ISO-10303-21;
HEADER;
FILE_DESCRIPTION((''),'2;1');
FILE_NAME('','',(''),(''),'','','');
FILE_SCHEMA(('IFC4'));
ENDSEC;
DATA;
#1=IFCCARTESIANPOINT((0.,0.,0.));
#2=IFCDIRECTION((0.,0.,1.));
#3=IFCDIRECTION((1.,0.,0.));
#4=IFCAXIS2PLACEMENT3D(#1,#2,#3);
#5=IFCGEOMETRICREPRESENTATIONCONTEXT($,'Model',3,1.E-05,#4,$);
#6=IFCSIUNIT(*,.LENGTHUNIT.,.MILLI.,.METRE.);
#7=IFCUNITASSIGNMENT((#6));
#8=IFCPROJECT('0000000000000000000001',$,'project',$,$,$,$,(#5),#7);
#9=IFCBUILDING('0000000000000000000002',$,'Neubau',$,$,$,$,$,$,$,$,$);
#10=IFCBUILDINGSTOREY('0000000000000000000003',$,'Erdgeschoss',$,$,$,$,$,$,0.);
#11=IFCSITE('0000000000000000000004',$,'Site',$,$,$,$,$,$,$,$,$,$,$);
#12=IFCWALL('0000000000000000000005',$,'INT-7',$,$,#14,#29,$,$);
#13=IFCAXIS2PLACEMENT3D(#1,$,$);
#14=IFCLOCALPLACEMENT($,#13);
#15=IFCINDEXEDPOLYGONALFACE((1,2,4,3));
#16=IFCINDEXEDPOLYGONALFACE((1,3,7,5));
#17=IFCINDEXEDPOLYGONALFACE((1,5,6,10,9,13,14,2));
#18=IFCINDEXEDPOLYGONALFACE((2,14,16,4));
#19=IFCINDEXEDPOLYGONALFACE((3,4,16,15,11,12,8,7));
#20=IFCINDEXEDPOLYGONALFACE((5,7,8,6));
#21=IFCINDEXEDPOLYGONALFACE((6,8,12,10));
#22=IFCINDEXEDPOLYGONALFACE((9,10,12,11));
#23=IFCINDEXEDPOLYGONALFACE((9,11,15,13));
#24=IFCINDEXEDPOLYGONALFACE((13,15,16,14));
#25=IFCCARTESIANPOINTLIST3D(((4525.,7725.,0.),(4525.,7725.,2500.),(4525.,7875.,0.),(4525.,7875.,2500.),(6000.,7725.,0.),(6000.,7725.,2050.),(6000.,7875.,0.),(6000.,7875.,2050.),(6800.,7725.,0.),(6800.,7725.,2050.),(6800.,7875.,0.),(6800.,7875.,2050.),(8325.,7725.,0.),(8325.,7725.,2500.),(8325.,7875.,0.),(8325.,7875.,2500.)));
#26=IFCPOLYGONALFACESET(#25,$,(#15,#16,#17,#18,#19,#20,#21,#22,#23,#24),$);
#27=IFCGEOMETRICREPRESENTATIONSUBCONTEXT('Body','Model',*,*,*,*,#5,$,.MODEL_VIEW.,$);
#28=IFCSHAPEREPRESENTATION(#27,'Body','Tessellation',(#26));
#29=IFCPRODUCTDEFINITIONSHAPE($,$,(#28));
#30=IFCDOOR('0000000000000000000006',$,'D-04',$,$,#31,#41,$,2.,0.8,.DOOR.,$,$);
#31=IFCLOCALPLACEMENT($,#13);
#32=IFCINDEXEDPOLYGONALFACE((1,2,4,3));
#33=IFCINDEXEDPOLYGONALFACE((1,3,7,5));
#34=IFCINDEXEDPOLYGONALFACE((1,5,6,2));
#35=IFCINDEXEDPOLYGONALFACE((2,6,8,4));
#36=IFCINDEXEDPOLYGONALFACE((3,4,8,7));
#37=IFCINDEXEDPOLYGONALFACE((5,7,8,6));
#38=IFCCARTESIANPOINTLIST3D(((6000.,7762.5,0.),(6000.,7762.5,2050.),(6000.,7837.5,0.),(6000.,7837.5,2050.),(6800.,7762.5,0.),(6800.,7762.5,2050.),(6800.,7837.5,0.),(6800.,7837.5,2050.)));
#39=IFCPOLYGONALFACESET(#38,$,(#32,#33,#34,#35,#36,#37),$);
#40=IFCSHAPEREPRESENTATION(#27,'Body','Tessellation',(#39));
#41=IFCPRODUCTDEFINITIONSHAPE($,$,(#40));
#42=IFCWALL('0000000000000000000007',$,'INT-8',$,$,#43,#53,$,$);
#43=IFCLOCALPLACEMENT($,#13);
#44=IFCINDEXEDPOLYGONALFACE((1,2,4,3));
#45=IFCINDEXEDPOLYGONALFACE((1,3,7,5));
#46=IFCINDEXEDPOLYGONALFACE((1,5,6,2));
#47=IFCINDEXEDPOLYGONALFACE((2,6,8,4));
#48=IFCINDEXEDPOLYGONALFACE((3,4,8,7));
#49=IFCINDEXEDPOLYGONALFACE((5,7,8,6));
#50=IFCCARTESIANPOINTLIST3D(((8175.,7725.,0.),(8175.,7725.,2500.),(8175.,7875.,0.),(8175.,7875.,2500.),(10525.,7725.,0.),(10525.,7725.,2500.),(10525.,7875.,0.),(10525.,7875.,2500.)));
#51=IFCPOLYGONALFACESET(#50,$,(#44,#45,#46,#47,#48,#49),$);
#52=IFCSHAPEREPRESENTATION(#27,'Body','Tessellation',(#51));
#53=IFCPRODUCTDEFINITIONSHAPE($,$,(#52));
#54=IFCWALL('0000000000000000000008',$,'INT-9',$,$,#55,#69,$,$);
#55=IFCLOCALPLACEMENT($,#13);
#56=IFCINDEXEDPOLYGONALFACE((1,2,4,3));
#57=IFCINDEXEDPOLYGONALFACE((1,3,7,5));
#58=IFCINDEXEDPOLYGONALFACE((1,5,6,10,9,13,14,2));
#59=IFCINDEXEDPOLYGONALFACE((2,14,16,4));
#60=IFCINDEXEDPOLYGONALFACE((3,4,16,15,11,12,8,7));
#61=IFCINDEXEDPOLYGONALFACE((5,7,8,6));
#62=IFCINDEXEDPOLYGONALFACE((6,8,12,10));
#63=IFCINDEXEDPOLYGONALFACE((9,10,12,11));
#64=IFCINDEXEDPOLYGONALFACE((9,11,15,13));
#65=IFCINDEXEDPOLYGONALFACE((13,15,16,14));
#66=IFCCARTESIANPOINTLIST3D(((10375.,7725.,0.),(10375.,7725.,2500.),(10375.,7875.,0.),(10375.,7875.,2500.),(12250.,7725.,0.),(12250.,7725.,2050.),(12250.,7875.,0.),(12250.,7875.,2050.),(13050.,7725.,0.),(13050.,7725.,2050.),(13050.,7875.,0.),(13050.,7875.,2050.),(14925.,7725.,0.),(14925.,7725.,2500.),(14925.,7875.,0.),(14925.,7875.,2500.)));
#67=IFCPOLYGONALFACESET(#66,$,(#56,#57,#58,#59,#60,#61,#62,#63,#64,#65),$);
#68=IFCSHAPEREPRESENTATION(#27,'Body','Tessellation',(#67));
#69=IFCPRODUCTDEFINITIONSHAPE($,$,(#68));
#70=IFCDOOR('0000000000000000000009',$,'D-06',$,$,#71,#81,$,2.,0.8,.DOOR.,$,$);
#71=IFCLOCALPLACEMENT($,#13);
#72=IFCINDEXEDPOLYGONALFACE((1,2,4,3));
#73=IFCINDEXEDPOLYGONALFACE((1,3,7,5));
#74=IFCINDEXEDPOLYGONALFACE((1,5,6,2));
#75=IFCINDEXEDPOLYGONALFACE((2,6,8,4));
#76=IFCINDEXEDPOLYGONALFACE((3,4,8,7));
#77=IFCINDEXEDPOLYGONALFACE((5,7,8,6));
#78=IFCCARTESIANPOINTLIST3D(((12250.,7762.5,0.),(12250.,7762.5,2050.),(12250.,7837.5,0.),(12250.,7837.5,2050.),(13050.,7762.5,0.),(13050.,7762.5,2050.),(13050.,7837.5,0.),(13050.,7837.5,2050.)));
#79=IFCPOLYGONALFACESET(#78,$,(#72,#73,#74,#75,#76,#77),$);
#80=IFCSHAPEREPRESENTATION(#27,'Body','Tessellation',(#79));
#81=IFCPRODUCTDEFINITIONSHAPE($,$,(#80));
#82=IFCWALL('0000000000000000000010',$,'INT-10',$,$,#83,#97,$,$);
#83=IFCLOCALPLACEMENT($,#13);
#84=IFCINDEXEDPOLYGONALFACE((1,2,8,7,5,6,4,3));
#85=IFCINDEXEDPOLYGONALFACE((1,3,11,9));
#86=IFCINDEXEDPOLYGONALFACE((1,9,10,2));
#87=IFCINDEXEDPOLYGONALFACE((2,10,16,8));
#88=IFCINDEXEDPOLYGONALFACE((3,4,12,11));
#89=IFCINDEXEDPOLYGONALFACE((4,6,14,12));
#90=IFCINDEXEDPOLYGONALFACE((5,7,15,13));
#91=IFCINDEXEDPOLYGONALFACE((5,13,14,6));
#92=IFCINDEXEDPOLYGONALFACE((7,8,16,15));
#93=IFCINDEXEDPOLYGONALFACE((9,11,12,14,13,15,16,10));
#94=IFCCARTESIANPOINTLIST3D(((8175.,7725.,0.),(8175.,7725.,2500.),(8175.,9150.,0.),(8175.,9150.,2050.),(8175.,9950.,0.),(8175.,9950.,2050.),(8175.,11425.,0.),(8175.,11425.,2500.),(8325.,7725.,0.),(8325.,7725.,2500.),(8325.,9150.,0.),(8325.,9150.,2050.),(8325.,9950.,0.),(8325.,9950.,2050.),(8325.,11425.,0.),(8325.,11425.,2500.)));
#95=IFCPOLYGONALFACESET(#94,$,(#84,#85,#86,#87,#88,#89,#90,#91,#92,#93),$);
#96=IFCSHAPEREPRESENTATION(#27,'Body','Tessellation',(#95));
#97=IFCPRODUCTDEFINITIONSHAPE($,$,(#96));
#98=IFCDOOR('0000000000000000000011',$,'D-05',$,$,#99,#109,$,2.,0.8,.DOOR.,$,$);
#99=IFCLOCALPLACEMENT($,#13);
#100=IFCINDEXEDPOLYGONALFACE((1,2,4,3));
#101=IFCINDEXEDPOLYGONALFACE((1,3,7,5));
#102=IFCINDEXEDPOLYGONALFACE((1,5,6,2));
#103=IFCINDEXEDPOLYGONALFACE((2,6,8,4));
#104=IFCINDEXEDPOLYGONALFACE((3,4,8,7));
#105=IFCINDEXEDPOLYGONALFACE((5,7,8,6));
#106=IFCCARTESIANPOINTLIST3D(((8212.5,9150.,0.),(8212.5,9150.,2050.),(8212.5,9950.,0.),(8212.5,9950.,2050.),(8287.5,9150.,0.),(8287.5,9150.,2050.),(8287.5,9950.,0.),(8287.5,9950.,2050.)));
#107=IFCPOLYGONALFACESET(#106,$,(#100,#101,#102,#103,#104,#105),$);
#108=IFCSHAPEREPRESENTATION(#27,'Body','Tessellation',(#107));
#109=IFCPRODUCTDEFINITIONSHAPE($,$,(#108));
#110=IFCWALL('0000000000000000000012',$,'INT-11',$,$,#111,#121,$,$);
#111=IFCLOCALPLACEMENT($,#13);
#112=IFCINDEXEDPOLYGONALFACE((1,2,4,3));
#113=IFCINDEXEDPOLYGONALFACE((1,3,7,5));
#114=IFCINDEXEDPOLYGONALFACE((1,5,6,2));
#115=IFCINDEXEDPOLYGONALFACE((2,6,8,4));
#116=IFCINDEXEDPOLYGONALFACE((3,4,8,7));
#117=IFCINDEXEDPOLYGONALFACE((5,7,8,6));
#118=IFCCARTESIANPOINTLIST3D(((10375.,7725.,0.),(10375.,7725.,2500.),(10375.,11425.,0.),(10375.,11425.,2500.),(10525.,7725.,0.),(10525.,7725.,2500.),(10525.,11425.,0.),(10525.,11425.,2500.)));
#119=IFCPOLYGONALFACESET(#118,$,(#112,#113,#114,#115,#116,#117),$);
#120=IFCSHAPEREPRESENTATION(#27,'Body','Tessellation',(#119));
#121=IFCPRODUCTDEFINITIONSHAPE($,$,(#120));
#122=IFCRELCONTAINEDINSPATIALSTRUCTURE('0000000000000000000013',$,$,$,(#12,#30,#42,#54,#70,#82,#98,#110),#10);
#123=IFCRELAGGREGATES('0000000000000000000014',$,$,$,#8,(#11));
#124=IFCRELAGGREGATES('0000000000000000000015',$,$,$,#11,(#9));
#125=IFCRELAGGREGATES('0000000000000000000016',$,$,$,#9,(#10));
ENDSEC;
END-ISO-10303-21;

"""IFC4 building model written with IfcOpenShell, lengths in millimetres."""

from ifc_helpers import new_model, si_unit, origin_with_axes, place, context, subcontext, project, spatial, indexed_curve, outline, extrude, element, fill, save


model = new_model("IFC4")

# Units and contexts
model_context = context("Model", 3, precision=1e-05, world=origin_with_axes())
body_context = subcontext(model_context, "Body", "Model", "MODEL_VIEW")
ifc_project = project(units=[si_unit("LENGTHUNIT", "METRE", prefix="MILLI")], contexts=[model_context])

# Site, building, storey
site = spatial("IfcSite", under=ifc_project, Name="Site")
building = spatial("IfcBuilding", under=site, Name="Neubau")
storey = spatial("IfcBuildingStorey", under=building, Name="Erdgeschoss", Elevation=0.0)

# Wall, opening, door
wall_1_placement = place(None, origin_with_axes())
wall_1 = element("IfcWall", 1, at=wall_1_placement, inside=storey, Name="INT-7", context=body_context, shape_type="SweptSolid", body=[
    extrude(outline(indexed_curve([(4525.0, 7875.0), (8325.0, 7875.0), (8325.0, 7725.0), (4525.0, 7725.0), (4525.0, 7875.0)])), origin_with_axes(), (0.0, 0.0, 1.0), 2500.0),
])
opening_1_placement = place(wall_1_placement, origin_with_axes())
opening_1 = element("IfcOpeningElement", 2, at=opening_1_placement, cuts=wall_1, context=body_context, shape_type="SweptSolid", body=[
    extrude(outline(indexed_curve([(6000.0, 7895.0), (6800.0, 7895.0), (6800.0, 7705.0), (6000.0, 7705.0), (6000.0, 7895.0)])), origin_with_axes(), (0.0, 0.0, 1.0), 2050.0),
])
door_1_placement = place(opening_1_placement, origin_with_axes())
door_1 = element("IfcDoor", 3, at=door_1_placement, inside=storey, Name="D-04", OverallHeight=2.0, OverallWidth=0.8, PredefinedType="DOOR", context=body_context, shape_type="SweptSolid", body=[
    extrude(outline(indexed_curve([(6000.0, 7837.5), (6800.0, 7837.5), (6800.0, 7762.5), (6000.0, 7762.5), (6000.0, 7837.5)])), origin_with_axes(), (0.0, 0.0, 1.0), 2050.0),
])
fill(opening_1, door_1)

# Wall
wall_2_placement = place(None, origin_with_axes())
element("IfcWall", 4, at=wall_2_placement, inside=storey, Name="INT-8", context=body_context, shape_type="SweptSolid", body=[
    extrude(outline(indexed_curve([(8175.0, 7875.0), (10525.0, 7875.0), (10525.0, 7725.0), (8175.0, 7725.0), (8175.0, 7875.0)])), origin_with_axes(), (0.0, 0.0, 1.0), 2500.0),
])

# Walls, openings, doors
wall_3_placement = place(None, origin_with_axes())
wall_3 = element("IfcWall", 5, at=wall_3_placement, inside=storey, Name="INT-9", context=body_context, shape_type="SweptSolid", body=[
    extrude(outline(indexed_curve([(10375.0, 7875.0), (14925.0, 7875.0), (14925.0, 7725.0), (10375.0, 7725.0), (10375.0, 7875.0)])), origin_with_axes(), (0.0, 0.0, 1.0), 2500.0),
])
opening_2_placement = place(wall_3_placement, origin_with_axes())
opening_2 = element("IfcOpeningElement", 6, at=opening_2_placement, cuts=wall_3, context=body_context, shape_type="SweptSolid", body=[
    extrude(outline(indexed_curve([(12250.0, 7895.0), (13050.0, 7895.0), (13050.0, 7705.0), (12250.0, 7705.0), (12250.0, 7895.0)])), origin_with_axes(), (0.0, 0.0, 1.0), 2050.0),
])
door_2_placement = place(opening_2_placement, origin_with_axes())
door_2 = element("IfcDoor", 7, at=door_2_placement, inside=storey, Name="D-06", OverallHeight=2.0, OverallWidth=0.8, PredefinedType="DOOR", context=body_context, shape_type="SweptSolid", body=[
    extrude(outline(indexed_curve([(12250.0, 7837.5), (13050.0, 7837.5), (13050.0, 7762.5), (12250.0, 7762.5), (12250.0, 7837.5)])), origin_with_axes(), (0.0, 0.0, 1.0), 2050.0),
])
fill(opening_2, door_2)
wall_4_placement = place(None, origin_with_axes())
wall_4 = element("IfcWall", 8, at=wall_4_placement, inside=storey, Name="INT-10", context=body_context, shape_type="SweptSolid", body=[
    extrude(outline(indexed_curve([(8175.0, 7725.0), (8175.0, 11425.0), (8325.0, 11425.0), (8325.0, 7725.0), (8175.0, 7725.0)])), origin_with_axes(), (0.0, 0.0, 1.0), 2500.0),
])
opening_3_placement = place(wall_4_placement, origin_with_axes())
opening_3 = element("IfcOpeningElement", 9, at=opening_3_placement, cuts=wall_4, context=body_context, shape_type="SweptSolid", body=[
    extrude(outline(indexed_curve([(8155.0, 9150.0), (8155.0, 9950.0), (8345.0, 9950.0), (8345.0, 9150.0), (8155.0, 9150.0)])), origin_with_axes(), (0.0, 0.0, 1.0), 2050.0),
])
door_3_placement = place(opening_3_placement, origin_with_axes())
door_3 = element("IfcDoor", 10, at=door_3_placement, inside=storey, Name="D-05", OverallHeight=2.0, OverallWidth=0.8, PredefinedType="DOOR", context=body_context, shape_type="SweptSolid", body=[
    extrude(outline(indexed_curve([(8212.5, 9150.0), (8212.5, 9950.0), (8287.5, 9950.0), (8287.5, 9150.0), (8212.5, 9150.0)])), origin_with_axes(), (0.0, 0.0, 1.0), 2050.0),
])
fill(opening_3, door_3)

# Wall
wall_5_placement = place(None, origin_with_axes())
element("IfcWall", 11, at=wall_5_placement, inside=storey, Name="INT-11", context=body_context, shape_type="SweptSolid", body=[
    extrude(outline(indexed_curve([(10375.0, 7725.0), (10375.0, 11425.0), (10525.0, 11425.0), (10525.0, 7725.0), (10375.0, 7725.0)])), origin_with_axes(), (0.0, 0.0, 1.0), 2500.0),
])

save(model, "model.ifc")
